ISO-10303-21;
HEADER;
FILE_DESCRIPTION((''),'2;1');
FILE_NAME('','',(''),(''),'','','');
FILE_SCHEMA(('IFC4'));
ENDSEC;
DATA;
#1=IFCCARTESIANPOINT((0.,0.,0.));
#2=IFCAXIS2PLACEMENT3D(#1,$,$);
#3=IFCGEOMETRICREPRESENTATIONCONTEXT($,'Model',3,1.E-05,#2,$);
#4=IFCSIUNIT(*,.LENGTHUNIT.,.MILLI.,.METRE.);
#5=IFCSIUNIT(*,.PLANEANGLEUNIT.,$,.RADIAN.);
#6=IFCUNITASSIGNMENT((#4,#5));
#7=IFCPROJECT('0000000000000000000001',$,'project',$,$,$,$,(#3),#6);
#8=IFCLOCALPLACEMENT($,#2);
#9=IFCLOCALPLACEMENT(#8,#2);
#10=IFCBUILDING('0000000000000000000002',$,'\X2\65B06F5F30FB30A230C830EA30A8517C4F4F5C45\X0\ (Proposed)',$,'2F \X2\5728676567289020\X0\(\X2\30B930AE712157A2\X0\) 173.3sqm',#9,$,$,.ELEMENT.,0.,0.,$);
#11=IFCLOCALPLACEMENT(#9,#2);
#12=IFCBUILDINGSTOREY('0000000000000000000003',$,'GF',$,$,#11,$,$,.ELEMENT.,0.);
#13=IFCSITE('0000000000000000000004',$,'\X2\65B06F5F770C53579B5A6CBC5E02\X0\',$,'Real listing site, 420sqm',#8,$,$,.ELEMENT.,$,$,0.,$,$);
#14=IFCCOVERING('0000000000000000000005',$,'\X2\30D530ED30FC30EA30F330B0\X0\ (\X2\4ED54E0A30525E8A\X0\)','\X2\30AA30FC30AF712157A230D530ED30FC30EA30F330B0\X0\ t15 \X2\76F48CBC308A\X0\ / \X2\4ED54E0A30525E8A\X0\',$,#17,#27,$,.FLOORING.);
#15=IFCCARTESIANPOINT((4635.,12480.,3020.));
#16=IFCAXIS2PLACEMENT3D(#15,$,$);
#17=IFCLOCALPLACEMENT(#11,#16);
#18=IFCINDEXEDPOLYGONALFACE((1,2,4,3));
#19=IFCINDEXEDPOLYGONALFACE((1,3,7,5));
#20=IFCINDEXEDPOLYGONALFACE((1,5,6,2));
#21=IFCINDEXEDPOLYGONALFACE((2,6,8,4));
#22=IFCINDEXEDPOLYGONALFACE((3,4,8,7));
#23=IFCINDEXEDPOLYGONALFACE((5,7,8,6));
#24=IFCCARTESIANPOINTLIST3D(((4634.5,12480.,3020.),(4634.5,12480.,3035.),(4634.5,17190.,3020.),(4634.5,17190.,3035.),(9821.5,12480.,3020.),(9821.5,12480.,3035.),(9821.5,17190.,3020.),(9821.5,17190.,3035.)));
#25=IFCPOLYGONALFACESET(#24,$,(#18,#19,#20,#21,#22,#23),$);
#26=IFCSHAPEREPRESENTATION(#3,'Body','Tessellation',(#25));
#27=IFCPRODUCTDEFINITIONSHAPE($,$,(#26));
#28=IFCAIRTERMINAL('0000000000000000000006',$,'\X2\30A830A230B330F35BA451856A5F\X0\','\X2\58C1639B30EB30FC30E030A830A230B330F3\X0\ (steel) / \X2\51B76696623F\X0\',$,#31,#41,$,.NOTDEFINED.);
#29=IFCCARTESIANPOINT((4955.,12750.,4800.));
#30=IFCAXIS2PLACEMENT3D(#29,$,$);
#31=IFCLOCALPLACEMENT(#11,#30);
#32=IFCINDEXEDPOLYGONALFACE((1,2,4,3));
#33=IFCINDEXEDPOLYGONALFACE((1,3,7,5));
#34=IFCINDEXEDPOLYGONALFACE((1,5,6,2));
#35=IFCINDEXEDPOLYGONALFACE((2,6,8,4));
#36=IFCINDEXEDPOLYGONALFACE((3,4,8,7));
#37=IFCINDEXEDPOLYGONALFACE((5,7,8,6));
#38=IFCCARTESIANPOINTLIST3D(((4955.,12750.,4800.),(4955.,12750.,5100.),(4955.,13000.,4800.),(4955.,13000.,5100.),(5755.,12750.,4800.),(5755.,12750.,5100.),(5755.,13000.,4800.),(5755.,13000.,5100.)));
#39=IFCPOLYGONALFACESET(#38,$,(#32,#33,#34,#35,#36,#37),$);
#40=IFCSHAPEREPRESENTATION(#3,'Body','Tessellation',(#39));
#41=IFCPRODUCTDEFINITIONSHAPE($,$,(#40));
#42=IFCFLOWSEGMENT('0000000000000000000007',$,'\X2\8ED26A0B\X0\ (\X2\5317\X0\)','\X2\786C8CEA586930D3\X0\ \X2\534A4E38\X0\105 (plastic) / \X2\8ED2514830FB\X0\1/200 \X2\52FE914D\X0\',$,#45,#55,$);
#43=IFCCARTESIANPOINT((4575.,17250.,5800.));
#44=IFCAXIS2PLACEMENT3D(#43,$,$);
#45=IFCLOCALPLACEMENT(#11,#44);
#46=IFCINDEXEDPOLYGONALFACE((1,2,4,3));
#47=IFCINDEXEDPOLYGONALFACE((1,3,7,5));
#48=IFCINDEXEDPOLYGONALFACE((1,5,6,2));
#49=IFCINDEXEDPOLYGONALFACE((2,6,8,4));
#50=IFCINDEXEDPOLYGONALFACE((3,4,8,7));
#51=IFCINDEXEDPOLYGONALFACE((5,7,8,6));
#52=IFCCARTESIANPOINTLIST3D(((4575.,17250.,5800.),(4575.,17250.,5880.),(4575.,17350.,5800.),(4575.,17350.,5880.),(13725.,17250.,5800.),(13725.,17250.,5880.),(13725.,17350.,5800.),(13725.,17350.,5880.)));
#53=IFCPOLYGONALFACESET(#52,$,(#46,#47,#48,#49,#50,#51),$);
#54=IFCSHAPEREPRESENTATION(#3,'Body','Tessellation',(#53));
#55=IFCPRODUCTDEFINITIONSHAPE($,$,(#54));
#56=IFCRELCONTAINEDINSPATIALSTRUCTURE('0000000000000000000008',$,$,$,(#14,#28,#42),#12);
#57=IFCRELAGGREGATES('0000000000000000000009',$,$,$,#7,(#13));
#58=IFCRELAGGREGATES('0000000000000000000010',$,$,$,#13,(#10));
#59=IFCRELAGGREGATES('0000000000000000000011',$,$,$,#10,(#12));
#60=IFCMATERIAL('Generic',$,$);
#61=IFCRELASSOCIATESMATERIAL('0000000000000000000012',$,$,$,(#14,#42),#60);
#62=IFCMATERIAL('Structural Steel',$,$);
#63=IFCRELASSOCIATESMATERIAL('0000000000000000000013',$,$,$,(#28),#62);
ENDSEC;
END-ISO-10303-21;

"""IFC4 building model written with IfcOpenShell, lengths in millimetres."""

from ifc_helpers import new_model, si_unit, frame, frame_2d, origin, place, context, project, spatial, rectangle, extrude, material, element, save


model = new_model("IFC4")

# Units and contexts
model_context = context("Model", 3, precision=1e-05, world=origin())
ifc_project = project(units=[si_unit("LENGTHUNIT", "METRE", prefix="MILLI"), si_unit("PLANEANGLEUNIT", "RADIAN")], contexts=[model_context])

# Site, building, storey
site_placement = place(None, origin())
site = spatial("IfcSite", under=ifc_project, at=site_placement, Name="新潟県南魚沼市", ObjectType="Real listing site, 420sqm", CompositionType="ELEMENT", RefElevation=0.0)
building_placement = place(site_placement, origin())
building = spatial("IfcBuilding", under=site, at=building_placement, Name="新潟・アトリエ兼住居 (Proposed)", ObjectType="2F 在来木造(スギ無垢) 173.3sqm", CompositionType="ELEMENT", ElevationOfRefHeight=0.0, ElevationOfTerrain=0.0)
storey_placement = place(building_placement, origin())
storey = spatial("IfcBuildingStorey", under=building, at=storey_placement, Name="GF", CompositionType="ELEMENT", Elevation=0.0)

# Shared definitions
ifc_material_1 = material(Name="Structural Steel")

# Covering
ifc_material_2 = material(Name="Generic")
covering_placement = place(storey_placement, frame((4635.0, 12480.0, 3020.0)))
element("IfcCovering", 1, at=covering_placement, inside=storey, material=ifc_material_2, Name="フローリング (仕上げ床)", Description="オーク無垢フローリング t15 直貼り / 仕上げ床", PredefinedType="FLOORING", context=model_context, shape_type="SweptSolid", body=[
    extrude(rectangle(XDim=5187.0, YDim=4710.0, at=frame_2d((2593.0, 2355.0))), frame((4635.0, 12480.0, 3020.0)), (0.0, 0.0, 1.0), 15.0),
])

# Air terminal
air_terminal_placement = place(storey_placement, frame((4955.0, 12750.0, 4800.0)))
element("IfcAirTerminal", 2, at=air_terminal_placement, inside=storey, material=ifc_material_1, Name="エアコン室内機", Description="壁掛ルームエアコン (steel) / 冷暖房", PredefinedType="NOTDEFINED", context=model_context, shape_type="SweptSolid", body=[
    extrude(rectangle(XDim=800.0, YDim=250.0, at=frame_2d((400.0, 125.0))), frame((4955.0, 12750.0, 4800.0)), (0.0, 0.0, 1.0), 300.0),
])

# Flow segment
flow_segment_placement = place(storey_placement, frame((4575.0, 17250.0, 5800.0)))
element("IfcFlowSegment", 3, at=flow_segment_placement, inside=storey, material=ifc_material_2, Name="軒樋 (北)", Description="硬質塩ビ 半丸105 (plastic) / 軒先・1/200 勾配", context=model_context, shape_type="SweptSolid", body=[
    extrude(rectangle(XDim=9150.0, YDim=100.0, at=frame_2d((4575.0, 50.0))), frame((4575.0, 17250.0, 5800.0)), (0.0, 0.0, 1.0), 80.0),
])

save(model, "model.ifc")
